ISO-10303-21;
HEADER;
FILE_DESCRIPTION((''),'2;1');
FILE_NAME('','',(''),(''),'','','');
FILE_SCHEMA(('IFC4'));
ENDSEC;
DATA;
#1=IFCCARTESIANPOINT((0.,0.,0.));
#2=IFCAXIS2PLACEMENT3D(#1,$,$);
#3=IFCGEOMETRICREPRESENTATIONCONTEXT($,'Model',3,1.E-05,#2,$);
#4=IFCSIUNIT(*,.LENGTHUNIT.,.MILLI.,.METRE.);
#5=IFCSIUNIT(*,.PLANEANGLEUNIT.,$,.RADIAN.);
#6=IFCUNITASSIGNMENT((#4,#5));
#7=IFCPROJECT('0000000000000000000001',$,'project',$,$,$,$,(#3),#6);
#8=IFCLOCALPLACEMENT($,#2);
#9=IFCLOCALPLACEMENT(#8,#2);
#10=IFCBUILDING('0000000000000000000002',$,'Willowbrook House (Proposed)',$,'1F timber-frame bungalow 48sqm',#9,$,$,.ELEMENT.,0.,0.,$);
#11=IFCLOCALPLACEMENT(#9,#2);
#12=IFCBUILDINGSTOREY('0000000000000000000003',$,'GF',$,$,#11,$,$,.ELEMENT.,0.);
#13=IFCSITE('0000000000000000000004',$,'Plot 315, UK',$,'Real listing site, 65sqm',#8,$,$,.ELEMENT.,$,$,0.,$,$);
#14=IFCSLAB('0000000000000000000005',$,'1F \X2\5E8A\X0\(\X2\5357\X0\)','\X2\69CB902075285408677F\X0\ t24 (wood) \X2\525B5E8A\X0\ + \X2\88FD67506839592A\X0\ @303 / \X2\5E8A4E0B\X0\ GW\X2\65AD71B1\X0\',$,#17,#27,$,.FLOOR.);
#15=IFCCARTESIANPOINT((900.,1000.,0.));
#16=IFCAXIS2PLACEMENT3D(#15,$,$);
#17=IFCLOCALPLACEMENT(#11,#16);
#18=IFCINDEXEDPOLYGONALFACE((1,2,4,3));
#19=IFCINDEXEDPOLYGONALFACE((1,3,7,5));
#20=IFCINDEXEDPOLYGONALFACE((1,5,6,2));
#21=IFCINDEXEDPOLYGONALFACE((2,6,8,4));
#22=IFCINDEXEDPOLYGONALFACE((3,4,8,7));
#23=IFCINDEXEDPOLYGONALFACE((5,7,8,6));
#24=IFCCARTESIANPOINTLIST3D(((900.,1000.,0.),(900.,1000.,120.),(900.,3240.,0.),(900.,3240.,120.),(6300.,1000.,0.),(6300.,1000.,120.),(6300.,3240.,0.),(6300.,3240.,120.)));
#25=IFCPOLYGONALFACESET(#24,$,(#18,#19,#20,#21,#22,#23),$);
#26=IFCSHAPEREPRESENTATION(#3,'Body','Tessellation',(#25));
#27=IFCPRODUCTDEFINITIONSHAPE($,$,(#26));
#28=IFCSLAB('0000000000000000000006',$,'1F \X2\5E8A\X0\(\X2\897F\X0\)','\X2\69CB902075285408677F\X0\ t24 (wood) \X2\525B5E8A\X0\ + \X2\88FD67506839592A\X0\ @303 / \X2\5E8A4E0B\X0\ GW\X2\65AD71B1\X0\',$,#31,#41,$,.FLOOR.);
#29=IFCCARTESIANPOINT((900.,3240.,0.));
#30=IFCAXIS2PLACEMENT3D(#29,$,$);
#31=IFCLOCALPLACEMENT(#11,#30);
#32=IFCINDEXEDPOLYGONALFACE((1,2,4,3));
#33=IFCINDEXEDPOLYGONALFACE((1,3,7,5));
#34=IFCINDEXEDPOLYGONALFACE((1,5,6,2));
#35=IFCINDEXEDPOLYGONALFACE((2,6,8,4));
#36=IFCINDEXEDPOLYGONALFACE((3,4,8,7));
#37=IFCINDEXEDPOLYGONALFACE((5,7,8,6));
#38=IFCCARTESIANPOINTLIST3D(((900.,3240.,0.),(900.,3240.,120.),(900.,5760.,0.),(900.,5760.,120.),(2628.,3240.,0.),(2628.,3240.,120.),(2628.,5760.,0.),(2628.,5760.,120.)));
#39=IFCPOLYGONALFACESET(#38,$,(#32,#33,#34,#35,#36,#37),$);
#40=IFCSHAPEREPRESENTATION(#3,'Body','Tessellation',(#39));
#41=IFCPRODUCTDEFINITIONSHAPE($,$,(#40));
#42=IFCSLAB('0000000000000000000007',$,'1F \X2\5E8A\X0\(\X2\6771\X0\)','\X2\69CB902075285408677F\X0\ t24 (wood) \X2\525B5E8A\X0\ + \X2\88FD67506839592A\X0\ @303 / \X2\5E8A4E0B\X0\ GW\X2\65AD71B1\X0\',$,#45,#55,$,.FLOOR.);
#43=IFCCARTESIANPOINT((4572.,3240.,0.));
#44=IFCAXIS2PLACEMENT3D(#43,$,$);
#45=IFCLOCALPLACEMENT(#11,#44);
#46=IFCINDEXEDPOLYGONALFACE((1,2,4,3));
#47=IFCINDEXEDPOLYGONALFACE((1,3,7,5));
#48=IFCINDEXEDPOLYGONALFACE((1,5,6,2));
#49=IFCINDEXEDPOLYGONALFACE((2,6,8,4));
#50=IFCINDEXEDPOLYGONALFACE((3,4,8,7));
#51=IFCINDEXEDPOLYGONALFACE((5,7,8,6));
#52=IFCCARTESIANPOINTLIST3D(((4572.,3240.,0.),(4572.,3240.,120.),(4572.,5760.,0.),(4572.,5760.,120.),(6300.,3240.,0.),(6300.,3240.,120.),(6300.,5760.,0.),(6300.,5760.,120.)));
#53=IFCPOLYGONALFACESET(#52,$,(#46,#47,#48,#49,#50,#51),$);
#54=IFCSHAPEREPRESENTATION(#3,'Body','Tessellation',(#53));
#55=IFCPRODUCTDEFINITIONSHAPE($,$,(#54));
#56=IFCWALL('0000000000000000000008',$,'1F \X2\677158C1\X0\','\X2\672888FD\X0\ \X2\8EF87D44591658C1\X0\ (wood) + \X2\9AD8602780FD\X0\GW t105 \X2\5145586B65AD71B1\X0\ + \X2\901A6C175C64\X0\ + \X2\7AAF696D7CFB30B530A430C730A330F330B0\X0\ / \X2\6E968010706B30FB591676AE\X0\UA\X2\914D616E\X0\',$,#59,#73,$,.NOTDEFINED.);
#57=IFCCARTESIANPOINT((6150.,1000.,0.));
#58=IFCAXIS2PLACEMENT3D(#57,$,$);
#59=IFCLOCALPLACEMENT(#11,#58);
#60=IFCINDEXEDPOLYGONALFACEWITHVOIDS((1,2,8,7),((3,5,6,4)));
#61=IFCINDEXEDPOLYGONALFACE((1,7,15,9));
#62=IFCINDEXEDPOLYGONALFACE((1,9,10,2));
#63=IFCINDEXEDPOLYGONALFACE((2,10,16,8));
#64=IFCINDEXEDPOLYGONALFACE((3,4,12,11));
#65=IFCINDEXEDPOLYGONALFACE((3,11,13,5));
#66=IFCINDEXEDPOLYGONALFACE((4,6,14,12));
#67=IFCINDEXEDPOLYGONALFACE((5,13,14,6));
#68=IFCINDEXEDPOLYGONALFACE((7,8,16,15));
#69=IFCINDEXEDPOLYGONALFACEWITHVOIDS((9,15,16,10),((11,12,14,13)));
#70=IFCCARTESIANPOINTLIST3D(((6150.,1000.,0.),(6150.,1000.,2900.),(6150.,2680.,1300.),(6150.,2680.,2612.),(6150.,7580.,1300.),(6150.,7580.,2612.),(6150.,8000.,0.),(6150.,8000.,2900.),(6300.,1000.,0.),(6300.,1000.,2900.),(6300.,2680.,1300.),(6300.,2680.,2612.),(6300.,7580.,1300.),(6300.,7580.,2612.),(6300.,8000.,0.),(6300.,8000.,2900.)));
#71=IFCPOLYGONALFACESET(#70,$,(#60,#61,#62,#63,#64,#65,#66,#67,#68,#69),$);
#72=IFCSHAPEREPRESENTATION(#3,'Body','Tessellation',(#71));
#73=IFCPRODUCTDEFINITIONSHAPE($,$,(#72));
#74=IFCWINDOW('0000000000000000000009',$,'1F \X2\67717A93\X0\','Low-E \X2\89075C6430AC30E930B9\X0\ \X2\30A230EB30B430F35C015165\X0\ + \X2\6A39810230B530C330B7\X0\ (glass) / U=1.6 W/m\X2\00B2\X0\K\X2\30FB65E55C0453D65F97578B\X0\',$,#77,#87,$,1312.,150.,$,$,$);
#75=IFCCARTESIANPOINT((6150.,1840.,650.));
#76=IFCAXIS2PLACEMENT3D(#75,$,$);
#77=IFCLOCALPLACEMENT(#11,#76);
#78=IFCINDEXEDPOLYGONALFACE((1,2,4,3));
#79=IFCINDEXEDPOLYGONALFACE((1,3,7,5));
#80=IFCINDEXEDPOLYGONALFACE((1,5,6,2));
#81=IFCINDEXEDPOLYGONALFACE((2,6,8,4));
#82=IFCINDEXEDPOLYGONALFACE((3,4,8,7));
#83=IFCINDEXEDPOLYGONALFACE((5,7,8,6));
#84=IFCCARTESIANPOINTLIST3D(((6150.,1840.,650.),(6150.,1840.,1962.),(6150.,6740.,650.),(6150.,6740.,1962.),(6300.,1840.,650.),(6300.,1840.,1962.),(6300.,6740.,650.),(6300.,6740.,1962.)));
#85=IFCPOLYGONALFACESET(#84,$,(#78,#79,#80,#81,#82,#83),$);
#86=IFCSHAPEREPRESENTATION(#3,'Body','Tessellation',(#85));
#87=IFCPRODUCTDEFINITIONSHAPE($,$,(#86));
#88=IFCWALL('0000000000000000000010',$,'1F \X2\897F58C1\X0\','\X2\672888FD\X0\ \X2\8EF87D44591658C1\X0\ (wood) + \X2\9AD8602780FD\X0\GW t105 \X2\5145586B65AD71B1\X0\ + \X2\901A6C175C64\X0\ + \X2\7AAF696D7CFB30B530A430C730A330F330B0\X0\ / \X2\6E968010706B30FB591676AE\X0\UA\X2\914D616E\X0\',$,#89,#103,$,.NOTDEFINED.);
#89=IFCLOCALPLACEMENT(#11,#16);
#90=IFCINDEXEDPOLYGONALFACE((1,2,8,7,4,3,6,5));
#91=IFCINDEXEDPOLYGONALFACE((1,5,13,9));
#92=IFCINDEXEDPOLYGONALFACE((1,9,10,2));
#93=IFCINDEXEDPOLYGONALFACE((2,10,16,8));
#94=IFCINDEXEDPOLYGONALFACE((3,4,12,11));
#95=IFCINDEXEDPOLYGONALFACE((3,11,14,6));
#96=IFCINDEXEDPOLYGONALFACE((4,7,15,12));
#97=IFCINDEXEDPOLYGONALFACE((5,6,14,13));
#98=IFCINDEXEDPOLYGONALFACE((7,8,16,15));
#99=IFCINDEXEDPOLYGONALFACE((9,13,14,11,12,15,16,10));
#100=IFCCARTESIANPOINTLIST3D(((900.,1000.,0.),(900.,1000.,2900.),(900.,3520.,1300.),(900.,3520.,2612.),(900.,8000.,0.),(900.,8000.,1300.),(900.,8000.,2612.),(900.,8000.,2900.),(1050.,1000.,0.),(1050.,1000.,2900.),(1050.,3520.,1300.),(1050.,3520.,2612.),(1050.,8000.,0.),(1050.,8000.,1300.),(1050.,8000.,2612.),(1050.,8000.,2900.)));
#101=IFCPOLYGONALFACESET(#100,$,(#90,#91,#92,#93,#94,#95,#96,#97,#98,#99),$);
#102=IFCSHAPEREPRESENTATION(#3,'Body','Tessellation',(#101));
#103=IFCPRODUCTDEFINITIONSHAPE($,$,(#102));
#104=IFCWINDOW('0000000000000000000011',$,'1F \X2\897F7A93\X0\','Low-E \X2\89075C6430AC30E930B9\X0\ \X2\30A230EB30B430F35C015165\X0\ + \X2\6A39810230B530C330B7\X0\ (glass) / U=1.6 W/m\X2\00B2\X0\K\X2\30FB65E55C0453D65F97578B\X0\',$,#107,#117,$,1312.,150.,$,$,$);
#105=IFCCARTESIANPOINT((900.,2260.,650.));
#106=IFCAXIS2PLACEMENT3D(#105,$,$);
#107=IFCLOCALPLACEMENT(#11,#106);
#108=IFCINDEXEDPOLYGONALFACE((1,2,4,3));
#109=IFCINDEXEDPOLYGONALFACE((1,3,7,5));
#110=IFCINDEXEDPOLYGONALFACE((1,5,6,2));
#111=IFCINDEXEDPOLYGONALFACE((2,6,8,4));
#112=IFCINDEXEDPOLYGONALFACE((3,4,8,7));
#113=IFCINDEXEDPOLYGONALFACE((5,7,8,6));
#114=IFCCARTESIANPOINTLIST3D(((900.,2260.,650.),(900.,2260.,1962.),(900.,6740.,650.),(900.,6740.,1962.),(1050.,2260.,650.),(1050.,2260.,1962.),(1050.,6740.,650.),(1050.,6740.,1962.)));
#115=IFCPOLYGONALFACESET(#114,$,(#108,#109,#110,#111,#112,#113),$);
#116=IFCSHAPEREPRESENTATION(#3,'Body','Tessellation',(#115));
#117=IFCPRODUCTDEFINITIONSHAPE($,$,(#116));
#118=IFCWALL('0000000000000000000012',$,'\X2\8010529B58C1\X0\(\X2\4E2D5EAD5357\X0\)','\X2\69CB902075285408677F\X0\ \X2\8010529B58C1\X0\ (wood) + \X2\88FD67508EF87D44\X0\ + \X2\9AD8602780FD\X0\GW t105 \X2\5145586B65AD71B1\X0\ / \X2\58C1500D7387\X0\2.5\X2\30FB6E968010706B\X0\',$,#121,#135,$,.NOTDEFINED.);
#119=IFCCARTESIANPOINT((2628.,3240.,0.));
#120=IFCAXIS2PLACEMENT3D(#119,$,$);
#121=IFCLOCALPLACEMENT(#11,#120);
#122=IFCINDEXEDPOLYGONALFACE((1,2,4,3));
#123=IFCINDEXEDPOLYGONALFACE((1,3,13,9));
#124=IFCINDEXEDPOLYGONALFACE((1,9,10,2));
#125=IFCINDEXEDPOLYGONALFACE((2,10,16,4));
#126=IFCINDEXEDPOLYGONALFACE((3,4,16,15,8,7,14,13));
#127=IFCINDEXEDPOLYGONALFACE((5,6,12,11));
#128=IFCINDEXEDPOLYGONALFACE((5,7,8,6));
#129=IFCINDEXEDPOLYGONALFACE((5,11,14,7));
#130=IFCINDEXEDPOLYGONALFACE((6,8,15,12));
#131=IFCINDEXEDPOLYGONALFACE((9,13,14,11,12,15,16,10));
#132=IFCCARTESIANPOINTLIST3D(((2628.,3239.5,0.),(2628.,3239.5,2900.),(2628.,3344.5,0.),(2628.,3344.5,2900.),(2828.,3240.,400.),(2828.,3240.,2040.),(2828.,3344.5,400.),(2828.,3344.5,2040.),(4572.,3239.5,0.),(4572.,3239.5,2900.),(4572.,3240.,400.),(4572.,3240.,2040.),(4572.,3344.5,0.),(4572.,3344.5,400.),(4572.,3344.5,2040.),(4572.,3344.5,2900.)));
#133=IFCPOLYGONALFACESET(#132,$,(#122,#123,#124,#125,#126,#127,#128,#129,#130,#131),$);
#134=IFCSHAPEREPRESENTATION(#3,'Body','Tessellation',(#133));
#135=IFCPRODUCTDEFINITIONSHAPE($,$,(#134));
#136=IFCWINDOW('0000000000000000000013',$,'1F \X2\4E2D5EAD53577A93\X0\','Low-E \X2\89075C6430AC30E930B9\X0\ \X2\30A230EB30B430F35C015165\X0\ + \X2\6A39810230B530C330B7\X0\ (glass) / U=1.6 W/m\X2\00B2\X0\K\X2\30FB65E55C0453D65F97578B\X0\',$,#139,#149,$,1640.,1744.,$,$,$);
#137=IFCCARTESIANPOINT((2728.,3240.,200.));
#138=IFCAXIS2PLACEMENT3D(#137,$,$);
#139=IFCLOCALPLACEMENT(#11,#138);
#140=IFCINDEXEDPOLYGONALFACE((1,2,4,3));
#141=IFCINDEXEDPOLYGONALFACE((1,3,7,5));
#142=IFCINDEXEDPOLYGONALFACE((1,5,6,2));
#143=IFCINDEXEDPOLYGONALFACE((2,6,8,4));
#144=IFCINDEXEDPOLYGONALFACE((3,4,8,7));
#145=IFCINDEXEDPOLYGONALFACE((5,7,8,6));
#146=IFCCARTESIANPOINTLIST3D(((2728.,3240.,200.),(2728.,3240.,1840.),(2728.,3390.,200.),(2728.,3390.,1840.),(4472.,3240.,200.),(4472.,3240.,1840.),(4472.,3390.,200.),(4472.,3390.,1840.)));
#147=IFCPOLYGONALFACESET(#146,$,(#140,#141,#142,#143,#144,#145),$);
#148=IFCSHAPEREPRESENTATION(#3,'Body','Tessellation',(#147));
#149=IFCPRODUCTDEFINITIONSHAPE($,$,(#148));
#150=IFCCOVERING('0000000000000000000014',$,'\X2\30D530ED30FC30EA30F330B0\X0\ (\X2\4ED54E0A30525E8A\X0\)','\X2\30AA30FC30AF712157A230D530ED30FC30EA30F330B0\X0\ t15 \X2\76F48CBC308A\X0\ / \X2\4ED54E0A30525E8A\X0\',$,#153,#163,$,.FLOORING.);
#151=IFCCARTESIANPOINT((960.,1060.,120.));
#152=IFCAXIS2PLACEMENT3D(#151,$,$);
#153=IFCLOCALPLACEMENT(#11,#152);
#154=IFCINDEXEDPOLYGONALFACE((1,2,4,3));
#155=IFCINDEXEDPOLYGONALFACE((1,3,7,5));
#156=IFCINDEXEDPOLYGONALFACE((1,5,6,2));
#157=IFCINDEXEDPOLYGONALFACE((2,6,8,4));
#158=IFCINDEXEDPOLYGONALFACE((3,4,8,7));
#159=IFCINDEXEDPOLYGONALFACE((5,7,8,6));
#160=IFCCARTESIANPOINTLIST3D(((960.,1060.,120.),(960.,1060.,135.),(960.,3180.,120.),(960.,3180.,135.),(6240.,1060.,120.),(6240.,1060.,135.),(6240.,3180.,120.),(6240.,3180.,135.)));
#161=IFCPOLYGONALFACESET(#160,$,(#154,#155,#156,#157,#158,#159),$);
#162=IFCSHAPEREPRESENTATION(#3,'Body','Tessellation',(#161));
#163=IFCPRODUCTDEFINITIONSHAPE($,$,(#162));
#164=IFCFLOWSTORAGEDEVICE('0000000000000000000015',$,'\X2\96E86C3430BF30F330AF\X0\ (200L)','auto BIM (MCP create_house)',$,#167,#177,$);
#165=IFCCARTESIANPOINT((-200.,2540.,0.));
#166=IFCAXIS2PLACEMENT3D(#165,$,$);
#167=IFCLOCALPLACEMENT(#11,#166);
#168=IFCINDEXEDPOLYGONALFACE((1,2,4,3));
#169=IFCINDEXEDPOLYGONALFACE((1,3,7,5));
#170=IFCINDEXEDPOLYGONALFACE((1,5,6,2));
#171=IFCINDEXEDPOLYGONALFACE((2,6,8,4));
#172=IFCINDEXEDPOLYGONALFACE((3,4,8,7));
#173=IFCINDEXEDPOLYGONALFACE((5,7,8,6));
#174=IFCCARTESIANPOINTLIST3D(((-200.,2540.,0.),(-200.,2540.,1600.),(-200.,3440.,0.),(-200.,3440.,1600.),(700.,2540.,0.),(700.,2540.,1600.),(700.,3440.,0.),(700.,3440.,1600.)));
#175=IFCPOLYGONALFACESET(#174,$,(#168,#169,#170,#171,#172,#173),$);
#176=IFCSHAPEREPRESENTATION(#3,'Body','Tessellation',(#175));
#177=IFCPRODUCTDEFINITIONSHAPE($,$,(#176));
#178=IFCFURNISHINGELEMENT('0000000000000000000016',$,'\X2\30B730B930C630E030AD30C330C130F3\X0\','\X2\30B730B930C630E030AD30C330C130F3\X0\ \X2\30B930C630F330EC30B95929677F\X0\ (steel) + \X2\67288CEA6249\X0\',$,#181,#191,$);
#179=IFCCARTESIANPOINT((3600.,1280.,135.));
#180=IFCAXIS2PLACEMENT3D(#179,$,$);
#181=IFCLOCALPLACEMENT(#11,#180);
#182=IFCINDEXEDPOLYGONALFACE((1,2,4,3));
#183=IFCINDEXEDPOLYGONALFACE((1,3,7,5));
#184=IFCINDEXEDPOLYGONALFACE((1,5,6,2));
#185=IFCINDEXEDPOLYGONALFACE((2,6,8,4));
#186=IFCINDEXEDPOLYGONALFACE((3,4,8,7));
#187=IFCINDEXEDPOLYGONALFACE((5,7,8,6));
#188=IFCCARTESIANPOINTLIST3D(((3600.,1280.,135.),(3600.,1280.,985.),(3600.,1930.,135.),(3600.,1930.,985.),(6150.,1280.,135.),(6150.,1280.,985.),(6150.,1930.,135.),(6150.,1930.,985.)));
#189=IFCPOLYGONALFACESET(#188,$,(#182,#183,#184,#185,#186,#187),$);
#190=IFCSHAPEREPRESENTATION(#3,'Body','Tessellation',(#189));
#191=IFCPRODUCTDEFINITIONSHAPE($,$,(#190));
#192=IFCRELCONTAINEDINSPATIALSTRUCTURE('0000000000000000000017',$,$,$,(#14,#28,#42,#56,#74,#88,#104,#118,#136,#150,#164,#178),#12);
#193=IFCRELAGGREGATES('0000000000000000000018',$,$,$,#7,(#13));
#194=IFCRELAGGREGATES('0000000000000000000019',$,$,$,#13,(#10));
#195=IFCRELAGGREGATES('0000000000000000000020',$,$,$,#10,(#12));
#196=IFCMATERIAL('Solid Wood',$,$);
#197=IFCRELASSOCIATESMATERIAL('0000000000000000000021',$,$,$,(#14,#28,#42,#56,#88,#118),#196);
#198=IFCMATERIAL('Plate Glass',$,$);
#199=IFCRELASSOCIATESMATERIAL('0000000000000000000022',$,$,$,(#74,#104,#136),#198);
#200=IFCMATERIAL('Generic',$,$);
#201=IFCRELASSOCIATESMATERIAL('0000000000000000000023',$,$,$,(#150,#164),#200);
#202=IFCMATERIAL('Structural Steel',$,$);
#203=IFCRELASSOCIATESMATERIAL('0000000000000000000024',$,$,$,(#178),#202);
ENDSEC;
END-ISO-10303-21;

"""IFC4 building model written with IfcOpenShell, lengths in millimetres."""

from ifc_helpers import new_model, si_unit, frame, frame_2d, origin, place, context, project, spatial, rectangle, extrude, material, element, fill, save


model = new_model("IFC4")

# Units and contexts
model_context = context("Model", 3, precision=1e-05, world=origin())
ifc_project = project(units=[si_unit("LENGTHUNIT", "METRE", prefix="MILLI"), si_unit("PLANEANGLEUNIT", "RADIAN")], contexts=[model_context])

# Site, building, storey
site_placement = place(None, origin())
site = spatial("IfcSite", under=ifc_project, at=site_placement, Name="Plot 315, UK", ObjectType="Real listing site, 65sqm", CompositionType="ELEMENT", RefElevation=0.0)
building_placement = place(site_placement, origin())
building = spatial("IfcBuilding", under=site, at=building_placement, Name="Willowbrook House (Proposed)", ObjectType="1F timber-frame bungalow 48sqm", CompositionType="ELEMENT", ElevationOfRefHeight=0.0, ElevationOfTerrain=0.0)
storey_placement = place(building_placement, origin())
storey = spatial("IfcBuildingStorey", under=building, at=storey_placement, Name="GF", CompositionType="ELEMENT", Elevation=0.0)

# Slabs
ifc_material_1 = material(Name="Solid Wood")
slab_1_placement = place(storey_placement, frame((900.0, 1000.0, 0.0)))
element("IfcSlab", 1, at=slab_1_placement, inside=storey, material=ifc_material_1, Name="1F 床(南)", Description="構造用合板 t24 (wood) 剛床 + 製材根太 @303 / 床下 GW断熱", PredefinedType="FLOOR", context=model_context, shape_type="SweptSolid", body=[
    extrude(rectangle(XDim=5400.0, YDim=2240.0, at=frame_2d((2700.0, 1120.0))), frame((900.0, 1000.0, 0.0)), (0.0, 0.0, 1.0), 120.0),
])
slab_2_placement = place(storey_placement, frame((900.0, 3240.0, 0.0)))
element("IfcSlab", 2, at=slab_2_placement, inside=storey, material=ifc_material_1, Name="1F 床(西)", Description="構造用合板 t24 (wood) 剛床 + 製材根太 @303 / 床下 GW断熱", PredefinedType="FLOOR", context=model_context, shape_type="SweptSolid", body=[
    extrude(rectangle(XDim=1728.0, YDim=2520.0, at=frame_2d((864.0, 1260.0))), frame((900.0, 3240.0, 0.0)), (0.0, 0.0, 1.0), 120.0),
])
slab_3_placement = place(storey_placement, frame((4572.0, 3240.0, 0.0)))
element("IfcSlab", 3, at=slab_3_placement, inside=storey, material=ifc_material_1, Name="1F 床(東)", Description="構造用合板 t24 (wood) 剛床 + 製材根太 @303 / 床下 GW断熱", PredefinedType="FLOOR", context=model_context, shape_type="SweptSolid", body=[
    extrude(rectangle(XDim=1728.0, YDim=2520.0, at=frame_2d((864.0, 1260.0))), frame((4572.0, 3240.0, 0.0)), (0.0, 0.0, 1.0), 120.0),
])
ifc_material_2 = material(Name="Generic")

# Shared definitions
ifc_material_3 = material(Name="Plate Glass")

# Walls, openings, windows
wall_1_placement = place(storey_placement, frame((6150.0, 1000.0, 0.0)))
wall_1 = element("IfcWall", 4, at=wall_1_placement, inside=storey, material=ifc_material_1, Name="1F 東壁", Description="木製 軸組外壁 (wood) + 高性能GW t105 充填断熱 + 通気層 + 窯業系サイディング / 準耐火・外皮UA配慮", PredefinedType="NOTDEFINED", context=model_context, shape_type="SweptSolid", body=[
    extrude(rectangle(XDim=150.0, YDim=7000.0, at=frame_2d((75.0, 3500.0))), frame((6150.0, 1000.0, 0.0)), (0.0, 0.0, 1.0), 2900.0),
])
opening_1_placement = place(storey_placement, frame((6150.0, 1840.0, 650.0)))
opening_1 = element("IfcOpeningElement", 5, at=opening_1_placement, cuts=wall_1, PredefinedType="NOTDEFINED", context=model_context, shape_type="SweptSolid", body=[
    extrude(rectangle(XDim=150.0, YDim=4900.0, at=frame_2d((75.0, 2450.0))), frame((6150.0, 1840.0, 650.0)), (0.0, 0.0, 1.0), 1312.0),
])
window_1_placement = place(storey_placement, frame((6150.0, 1840.0, 650.0)))
window_1 = element("IfcWindow", 6, at=window_1_placement, inside=storey, material=ifc_material_3, Name="1F 東窓", Description="Low-E 複層ガラス アルゴン封入 + 樹脂サッシ (glass) / U=1.6 W/m²K・日射取得型", OverallHeight=1312.0, OverallWidth=150.0, context=model_context, shape_type="SweptSolid", body=[
    extrude(rectangle(XDim=150.0, YDim=4900.0, at=frame_2d((75.0, 2450.0))), frame((6150.0, 1840.0, 650.0)), (0.0, 0.0, 1.0), 1312.0),
])
fill(opening_1, window_1)
wall_2_placement = place(storey_placement, frame((900.0, 1000.0, 0.0)))
wall_2 = element("IfcWall", 7, at=wall_2_placement, inside=storey, material=ifc_material_1, Name="1F 西壁", Description="木製 軸組外壁 (wood) + 高性能GW t105 充填断熱 + 通気層 + 窯業系サイディング / 準耐火・外皮UA配慮", PredefinedType="NOTDEFINED", context=model_context, shape_type="SweptSolid", body=[
    extrude(rectangle(XDim=150.0, YDim=7000.0, at=frame_2d((75.0, 3500.0))), frame((900.0, 1000.0, 0.0)), (0.0, 0.0, 1.0), 2900.0),
])
opening_2_placement = place(storey_placement, frame((900.0, 2260.0, 650.0)))
opening_2 = element("IfcOpeningElement", 8, at=opening_2_placement, cuts=wall_2, PredefinedType="NOTDEFINED", context=model_context, shape_type="SweptSolid", body=[
    extrude(rectangle(XDim=150.0, YDim=4480.0, at=frame_2d((75.0, 2240.0))), frame((900.0, 2260.0, 650.0)), (0.0, 0.0, 1.0), 1312.0),
])
window_2_placement = place(storey_placement, frame((900.0, 2260.0, 650.0)))
window_2 = element("IfcWindow", 9, at=window_2_placement, inside=storey, material=ifc_material_3, Name="1F 西窓", Description="Low-E 複層ガラス アルゴン封入 + 樹脂サッシ (glass) / U=1.6 W/m²K・日射取得型", OverallHeight=1312.0, OverallWidth=150.0, context=model_context, shape_type="SweptSolid", body=[
    extrude(rectangle(XDim=150.0, YDim=4480.0, at=frame_2d((75.0, 2240.0))), frame((900.0, 2260.0, 650.0)), (0.0, 0.0, 1.0), 1312.0),
])
fill(opening_2, window_2)
wall_3_placement = place(storey_placement, frame((2628.0, 3240.0, 0.0)))
wall_3 = element("IfcWall", 10, at=wall_3_placement, inside=storey, material=ifc_material_1, Name="耐力壁(中庭南)", Description="構造用合板 耐力壁 (wood) + 製材軸組 + 高性能GW t105 充填断熱 / 壁倍率2.5・準耐火", PredefinedType="NOTDEFINED", context=model_context, shape_type="SweptSolid", body=[
    extrude(rectangle(XDim=1944.0, YDim=105.0, at=frame_2d((972.0, 52.0))), frame((2628.0, 3240.0, 0.0)), (0.0, 0.0, 1.0), 2900.0),
])
opening_3_placement = place(storey_placement, frame((2728.0, 3240.0, 200.0)))
opening_3 = element("IfcOpeningElement", 11, at=opening_3_placement, cuts=wall_3, PredefinedType="NOTDEFINED", context=model_context, shape_type="SweptSolid", body=[
    extrude(rectangle(XDim=1744.0, YDim=150.0, at=frame_2d((872.0, 75.0))), frame((2728.0, 3240.0, 200.0)), (0.0, 0.0, 1.0), 1640.0),
])
window_3_placement = place(storey_placement, frame((2728.0, 3240.0, 200.0)))
window_3 = element("IfcWindow", 12, at=window_3_placement, inside=storey, material=ifc_material_3, Name="1F 中庭南窓", Description="Low-E 複層ガラス アルゴン封入 + 樹脂サッシ (glass) / U=1.6 W/m²K・日射取得型", OverallHeight=1640.0, OverallWidth=1744.0, context=model_context, shape_type="SweptSolid", body=[
    extrude(rectangle(XDim=1744.0, YDim=150.0, at=frame_2d((872.0, 75.0))), frame((2728.0, 3240.0, 200.0)), (0.0, 0.0, 1.0), 1640.0),
])
fill(opening_3, window_3)

# Covering
covering_placement = place(storey_placement, frame((960.0, 1060.0, 120.0)))
element("IfcCovering", 13, at=covering_placement, inside=storey, material=ifc_material_2, Name="フローリング (仕上げ床)", Description="オーク無垢フローリング t15 直貼り / 仕上げ床", PredefinedType="FLOORING", context=model_context, shape_type="SweptSolid", body=[
    extrude(rectangle(XDim=5280.0, YDim=2120.0, at=frame_2d((2640.0, 1060.0))), frame((960.0, 1060.0, 120.0)), (0.0, 0.0, 1.0), 15.0),
])

# Flow storage device
flow_storage_device_placement = place(storey_placement, frame((-200.0, 2540.0, 0.0)))
element("IfcFlowStorageDevice", 14, at=flow_storage_device_placement, inside=storey, material=ifc_material_2, Name="雨水タンク (200L)", Description="auto BIM (MCP create_house)", context=model_context, shape_type="SweptSolid", body=[
    extrude(rectangle(XDim=900.0, YDim=900.0, at=frame_2d((450.0, 450.0))), frame((-200.0, 2540.0, 0.0)), (0.0, 0.0, 1.0), 1600.0),
])

# Furnishing element
ifc_material_4 = material(Name="Structural Steel")
furnishing_placement = place(storey_placement, frame((3600.0, 1280.0, 135.0)))
element("IfcFurnishingElement", 15, at=furnishing_placement, inside=storey, material=ifc_material_4, Name="システムキッチン", Description="システムキッチン ステンレス天板 (steel) + 木質扉", context=model_context, shape_type="SweptSolid", body=[
    extrude(rectangle(XDim=2550.0, YDim=650.0, at=frame_2d((1275.0, 325.0))), frame((3600.0, 1280.0, 135.0)), (0.0, 0.0, 1.0), 850.0),
])

save(model, "model.ifc")
